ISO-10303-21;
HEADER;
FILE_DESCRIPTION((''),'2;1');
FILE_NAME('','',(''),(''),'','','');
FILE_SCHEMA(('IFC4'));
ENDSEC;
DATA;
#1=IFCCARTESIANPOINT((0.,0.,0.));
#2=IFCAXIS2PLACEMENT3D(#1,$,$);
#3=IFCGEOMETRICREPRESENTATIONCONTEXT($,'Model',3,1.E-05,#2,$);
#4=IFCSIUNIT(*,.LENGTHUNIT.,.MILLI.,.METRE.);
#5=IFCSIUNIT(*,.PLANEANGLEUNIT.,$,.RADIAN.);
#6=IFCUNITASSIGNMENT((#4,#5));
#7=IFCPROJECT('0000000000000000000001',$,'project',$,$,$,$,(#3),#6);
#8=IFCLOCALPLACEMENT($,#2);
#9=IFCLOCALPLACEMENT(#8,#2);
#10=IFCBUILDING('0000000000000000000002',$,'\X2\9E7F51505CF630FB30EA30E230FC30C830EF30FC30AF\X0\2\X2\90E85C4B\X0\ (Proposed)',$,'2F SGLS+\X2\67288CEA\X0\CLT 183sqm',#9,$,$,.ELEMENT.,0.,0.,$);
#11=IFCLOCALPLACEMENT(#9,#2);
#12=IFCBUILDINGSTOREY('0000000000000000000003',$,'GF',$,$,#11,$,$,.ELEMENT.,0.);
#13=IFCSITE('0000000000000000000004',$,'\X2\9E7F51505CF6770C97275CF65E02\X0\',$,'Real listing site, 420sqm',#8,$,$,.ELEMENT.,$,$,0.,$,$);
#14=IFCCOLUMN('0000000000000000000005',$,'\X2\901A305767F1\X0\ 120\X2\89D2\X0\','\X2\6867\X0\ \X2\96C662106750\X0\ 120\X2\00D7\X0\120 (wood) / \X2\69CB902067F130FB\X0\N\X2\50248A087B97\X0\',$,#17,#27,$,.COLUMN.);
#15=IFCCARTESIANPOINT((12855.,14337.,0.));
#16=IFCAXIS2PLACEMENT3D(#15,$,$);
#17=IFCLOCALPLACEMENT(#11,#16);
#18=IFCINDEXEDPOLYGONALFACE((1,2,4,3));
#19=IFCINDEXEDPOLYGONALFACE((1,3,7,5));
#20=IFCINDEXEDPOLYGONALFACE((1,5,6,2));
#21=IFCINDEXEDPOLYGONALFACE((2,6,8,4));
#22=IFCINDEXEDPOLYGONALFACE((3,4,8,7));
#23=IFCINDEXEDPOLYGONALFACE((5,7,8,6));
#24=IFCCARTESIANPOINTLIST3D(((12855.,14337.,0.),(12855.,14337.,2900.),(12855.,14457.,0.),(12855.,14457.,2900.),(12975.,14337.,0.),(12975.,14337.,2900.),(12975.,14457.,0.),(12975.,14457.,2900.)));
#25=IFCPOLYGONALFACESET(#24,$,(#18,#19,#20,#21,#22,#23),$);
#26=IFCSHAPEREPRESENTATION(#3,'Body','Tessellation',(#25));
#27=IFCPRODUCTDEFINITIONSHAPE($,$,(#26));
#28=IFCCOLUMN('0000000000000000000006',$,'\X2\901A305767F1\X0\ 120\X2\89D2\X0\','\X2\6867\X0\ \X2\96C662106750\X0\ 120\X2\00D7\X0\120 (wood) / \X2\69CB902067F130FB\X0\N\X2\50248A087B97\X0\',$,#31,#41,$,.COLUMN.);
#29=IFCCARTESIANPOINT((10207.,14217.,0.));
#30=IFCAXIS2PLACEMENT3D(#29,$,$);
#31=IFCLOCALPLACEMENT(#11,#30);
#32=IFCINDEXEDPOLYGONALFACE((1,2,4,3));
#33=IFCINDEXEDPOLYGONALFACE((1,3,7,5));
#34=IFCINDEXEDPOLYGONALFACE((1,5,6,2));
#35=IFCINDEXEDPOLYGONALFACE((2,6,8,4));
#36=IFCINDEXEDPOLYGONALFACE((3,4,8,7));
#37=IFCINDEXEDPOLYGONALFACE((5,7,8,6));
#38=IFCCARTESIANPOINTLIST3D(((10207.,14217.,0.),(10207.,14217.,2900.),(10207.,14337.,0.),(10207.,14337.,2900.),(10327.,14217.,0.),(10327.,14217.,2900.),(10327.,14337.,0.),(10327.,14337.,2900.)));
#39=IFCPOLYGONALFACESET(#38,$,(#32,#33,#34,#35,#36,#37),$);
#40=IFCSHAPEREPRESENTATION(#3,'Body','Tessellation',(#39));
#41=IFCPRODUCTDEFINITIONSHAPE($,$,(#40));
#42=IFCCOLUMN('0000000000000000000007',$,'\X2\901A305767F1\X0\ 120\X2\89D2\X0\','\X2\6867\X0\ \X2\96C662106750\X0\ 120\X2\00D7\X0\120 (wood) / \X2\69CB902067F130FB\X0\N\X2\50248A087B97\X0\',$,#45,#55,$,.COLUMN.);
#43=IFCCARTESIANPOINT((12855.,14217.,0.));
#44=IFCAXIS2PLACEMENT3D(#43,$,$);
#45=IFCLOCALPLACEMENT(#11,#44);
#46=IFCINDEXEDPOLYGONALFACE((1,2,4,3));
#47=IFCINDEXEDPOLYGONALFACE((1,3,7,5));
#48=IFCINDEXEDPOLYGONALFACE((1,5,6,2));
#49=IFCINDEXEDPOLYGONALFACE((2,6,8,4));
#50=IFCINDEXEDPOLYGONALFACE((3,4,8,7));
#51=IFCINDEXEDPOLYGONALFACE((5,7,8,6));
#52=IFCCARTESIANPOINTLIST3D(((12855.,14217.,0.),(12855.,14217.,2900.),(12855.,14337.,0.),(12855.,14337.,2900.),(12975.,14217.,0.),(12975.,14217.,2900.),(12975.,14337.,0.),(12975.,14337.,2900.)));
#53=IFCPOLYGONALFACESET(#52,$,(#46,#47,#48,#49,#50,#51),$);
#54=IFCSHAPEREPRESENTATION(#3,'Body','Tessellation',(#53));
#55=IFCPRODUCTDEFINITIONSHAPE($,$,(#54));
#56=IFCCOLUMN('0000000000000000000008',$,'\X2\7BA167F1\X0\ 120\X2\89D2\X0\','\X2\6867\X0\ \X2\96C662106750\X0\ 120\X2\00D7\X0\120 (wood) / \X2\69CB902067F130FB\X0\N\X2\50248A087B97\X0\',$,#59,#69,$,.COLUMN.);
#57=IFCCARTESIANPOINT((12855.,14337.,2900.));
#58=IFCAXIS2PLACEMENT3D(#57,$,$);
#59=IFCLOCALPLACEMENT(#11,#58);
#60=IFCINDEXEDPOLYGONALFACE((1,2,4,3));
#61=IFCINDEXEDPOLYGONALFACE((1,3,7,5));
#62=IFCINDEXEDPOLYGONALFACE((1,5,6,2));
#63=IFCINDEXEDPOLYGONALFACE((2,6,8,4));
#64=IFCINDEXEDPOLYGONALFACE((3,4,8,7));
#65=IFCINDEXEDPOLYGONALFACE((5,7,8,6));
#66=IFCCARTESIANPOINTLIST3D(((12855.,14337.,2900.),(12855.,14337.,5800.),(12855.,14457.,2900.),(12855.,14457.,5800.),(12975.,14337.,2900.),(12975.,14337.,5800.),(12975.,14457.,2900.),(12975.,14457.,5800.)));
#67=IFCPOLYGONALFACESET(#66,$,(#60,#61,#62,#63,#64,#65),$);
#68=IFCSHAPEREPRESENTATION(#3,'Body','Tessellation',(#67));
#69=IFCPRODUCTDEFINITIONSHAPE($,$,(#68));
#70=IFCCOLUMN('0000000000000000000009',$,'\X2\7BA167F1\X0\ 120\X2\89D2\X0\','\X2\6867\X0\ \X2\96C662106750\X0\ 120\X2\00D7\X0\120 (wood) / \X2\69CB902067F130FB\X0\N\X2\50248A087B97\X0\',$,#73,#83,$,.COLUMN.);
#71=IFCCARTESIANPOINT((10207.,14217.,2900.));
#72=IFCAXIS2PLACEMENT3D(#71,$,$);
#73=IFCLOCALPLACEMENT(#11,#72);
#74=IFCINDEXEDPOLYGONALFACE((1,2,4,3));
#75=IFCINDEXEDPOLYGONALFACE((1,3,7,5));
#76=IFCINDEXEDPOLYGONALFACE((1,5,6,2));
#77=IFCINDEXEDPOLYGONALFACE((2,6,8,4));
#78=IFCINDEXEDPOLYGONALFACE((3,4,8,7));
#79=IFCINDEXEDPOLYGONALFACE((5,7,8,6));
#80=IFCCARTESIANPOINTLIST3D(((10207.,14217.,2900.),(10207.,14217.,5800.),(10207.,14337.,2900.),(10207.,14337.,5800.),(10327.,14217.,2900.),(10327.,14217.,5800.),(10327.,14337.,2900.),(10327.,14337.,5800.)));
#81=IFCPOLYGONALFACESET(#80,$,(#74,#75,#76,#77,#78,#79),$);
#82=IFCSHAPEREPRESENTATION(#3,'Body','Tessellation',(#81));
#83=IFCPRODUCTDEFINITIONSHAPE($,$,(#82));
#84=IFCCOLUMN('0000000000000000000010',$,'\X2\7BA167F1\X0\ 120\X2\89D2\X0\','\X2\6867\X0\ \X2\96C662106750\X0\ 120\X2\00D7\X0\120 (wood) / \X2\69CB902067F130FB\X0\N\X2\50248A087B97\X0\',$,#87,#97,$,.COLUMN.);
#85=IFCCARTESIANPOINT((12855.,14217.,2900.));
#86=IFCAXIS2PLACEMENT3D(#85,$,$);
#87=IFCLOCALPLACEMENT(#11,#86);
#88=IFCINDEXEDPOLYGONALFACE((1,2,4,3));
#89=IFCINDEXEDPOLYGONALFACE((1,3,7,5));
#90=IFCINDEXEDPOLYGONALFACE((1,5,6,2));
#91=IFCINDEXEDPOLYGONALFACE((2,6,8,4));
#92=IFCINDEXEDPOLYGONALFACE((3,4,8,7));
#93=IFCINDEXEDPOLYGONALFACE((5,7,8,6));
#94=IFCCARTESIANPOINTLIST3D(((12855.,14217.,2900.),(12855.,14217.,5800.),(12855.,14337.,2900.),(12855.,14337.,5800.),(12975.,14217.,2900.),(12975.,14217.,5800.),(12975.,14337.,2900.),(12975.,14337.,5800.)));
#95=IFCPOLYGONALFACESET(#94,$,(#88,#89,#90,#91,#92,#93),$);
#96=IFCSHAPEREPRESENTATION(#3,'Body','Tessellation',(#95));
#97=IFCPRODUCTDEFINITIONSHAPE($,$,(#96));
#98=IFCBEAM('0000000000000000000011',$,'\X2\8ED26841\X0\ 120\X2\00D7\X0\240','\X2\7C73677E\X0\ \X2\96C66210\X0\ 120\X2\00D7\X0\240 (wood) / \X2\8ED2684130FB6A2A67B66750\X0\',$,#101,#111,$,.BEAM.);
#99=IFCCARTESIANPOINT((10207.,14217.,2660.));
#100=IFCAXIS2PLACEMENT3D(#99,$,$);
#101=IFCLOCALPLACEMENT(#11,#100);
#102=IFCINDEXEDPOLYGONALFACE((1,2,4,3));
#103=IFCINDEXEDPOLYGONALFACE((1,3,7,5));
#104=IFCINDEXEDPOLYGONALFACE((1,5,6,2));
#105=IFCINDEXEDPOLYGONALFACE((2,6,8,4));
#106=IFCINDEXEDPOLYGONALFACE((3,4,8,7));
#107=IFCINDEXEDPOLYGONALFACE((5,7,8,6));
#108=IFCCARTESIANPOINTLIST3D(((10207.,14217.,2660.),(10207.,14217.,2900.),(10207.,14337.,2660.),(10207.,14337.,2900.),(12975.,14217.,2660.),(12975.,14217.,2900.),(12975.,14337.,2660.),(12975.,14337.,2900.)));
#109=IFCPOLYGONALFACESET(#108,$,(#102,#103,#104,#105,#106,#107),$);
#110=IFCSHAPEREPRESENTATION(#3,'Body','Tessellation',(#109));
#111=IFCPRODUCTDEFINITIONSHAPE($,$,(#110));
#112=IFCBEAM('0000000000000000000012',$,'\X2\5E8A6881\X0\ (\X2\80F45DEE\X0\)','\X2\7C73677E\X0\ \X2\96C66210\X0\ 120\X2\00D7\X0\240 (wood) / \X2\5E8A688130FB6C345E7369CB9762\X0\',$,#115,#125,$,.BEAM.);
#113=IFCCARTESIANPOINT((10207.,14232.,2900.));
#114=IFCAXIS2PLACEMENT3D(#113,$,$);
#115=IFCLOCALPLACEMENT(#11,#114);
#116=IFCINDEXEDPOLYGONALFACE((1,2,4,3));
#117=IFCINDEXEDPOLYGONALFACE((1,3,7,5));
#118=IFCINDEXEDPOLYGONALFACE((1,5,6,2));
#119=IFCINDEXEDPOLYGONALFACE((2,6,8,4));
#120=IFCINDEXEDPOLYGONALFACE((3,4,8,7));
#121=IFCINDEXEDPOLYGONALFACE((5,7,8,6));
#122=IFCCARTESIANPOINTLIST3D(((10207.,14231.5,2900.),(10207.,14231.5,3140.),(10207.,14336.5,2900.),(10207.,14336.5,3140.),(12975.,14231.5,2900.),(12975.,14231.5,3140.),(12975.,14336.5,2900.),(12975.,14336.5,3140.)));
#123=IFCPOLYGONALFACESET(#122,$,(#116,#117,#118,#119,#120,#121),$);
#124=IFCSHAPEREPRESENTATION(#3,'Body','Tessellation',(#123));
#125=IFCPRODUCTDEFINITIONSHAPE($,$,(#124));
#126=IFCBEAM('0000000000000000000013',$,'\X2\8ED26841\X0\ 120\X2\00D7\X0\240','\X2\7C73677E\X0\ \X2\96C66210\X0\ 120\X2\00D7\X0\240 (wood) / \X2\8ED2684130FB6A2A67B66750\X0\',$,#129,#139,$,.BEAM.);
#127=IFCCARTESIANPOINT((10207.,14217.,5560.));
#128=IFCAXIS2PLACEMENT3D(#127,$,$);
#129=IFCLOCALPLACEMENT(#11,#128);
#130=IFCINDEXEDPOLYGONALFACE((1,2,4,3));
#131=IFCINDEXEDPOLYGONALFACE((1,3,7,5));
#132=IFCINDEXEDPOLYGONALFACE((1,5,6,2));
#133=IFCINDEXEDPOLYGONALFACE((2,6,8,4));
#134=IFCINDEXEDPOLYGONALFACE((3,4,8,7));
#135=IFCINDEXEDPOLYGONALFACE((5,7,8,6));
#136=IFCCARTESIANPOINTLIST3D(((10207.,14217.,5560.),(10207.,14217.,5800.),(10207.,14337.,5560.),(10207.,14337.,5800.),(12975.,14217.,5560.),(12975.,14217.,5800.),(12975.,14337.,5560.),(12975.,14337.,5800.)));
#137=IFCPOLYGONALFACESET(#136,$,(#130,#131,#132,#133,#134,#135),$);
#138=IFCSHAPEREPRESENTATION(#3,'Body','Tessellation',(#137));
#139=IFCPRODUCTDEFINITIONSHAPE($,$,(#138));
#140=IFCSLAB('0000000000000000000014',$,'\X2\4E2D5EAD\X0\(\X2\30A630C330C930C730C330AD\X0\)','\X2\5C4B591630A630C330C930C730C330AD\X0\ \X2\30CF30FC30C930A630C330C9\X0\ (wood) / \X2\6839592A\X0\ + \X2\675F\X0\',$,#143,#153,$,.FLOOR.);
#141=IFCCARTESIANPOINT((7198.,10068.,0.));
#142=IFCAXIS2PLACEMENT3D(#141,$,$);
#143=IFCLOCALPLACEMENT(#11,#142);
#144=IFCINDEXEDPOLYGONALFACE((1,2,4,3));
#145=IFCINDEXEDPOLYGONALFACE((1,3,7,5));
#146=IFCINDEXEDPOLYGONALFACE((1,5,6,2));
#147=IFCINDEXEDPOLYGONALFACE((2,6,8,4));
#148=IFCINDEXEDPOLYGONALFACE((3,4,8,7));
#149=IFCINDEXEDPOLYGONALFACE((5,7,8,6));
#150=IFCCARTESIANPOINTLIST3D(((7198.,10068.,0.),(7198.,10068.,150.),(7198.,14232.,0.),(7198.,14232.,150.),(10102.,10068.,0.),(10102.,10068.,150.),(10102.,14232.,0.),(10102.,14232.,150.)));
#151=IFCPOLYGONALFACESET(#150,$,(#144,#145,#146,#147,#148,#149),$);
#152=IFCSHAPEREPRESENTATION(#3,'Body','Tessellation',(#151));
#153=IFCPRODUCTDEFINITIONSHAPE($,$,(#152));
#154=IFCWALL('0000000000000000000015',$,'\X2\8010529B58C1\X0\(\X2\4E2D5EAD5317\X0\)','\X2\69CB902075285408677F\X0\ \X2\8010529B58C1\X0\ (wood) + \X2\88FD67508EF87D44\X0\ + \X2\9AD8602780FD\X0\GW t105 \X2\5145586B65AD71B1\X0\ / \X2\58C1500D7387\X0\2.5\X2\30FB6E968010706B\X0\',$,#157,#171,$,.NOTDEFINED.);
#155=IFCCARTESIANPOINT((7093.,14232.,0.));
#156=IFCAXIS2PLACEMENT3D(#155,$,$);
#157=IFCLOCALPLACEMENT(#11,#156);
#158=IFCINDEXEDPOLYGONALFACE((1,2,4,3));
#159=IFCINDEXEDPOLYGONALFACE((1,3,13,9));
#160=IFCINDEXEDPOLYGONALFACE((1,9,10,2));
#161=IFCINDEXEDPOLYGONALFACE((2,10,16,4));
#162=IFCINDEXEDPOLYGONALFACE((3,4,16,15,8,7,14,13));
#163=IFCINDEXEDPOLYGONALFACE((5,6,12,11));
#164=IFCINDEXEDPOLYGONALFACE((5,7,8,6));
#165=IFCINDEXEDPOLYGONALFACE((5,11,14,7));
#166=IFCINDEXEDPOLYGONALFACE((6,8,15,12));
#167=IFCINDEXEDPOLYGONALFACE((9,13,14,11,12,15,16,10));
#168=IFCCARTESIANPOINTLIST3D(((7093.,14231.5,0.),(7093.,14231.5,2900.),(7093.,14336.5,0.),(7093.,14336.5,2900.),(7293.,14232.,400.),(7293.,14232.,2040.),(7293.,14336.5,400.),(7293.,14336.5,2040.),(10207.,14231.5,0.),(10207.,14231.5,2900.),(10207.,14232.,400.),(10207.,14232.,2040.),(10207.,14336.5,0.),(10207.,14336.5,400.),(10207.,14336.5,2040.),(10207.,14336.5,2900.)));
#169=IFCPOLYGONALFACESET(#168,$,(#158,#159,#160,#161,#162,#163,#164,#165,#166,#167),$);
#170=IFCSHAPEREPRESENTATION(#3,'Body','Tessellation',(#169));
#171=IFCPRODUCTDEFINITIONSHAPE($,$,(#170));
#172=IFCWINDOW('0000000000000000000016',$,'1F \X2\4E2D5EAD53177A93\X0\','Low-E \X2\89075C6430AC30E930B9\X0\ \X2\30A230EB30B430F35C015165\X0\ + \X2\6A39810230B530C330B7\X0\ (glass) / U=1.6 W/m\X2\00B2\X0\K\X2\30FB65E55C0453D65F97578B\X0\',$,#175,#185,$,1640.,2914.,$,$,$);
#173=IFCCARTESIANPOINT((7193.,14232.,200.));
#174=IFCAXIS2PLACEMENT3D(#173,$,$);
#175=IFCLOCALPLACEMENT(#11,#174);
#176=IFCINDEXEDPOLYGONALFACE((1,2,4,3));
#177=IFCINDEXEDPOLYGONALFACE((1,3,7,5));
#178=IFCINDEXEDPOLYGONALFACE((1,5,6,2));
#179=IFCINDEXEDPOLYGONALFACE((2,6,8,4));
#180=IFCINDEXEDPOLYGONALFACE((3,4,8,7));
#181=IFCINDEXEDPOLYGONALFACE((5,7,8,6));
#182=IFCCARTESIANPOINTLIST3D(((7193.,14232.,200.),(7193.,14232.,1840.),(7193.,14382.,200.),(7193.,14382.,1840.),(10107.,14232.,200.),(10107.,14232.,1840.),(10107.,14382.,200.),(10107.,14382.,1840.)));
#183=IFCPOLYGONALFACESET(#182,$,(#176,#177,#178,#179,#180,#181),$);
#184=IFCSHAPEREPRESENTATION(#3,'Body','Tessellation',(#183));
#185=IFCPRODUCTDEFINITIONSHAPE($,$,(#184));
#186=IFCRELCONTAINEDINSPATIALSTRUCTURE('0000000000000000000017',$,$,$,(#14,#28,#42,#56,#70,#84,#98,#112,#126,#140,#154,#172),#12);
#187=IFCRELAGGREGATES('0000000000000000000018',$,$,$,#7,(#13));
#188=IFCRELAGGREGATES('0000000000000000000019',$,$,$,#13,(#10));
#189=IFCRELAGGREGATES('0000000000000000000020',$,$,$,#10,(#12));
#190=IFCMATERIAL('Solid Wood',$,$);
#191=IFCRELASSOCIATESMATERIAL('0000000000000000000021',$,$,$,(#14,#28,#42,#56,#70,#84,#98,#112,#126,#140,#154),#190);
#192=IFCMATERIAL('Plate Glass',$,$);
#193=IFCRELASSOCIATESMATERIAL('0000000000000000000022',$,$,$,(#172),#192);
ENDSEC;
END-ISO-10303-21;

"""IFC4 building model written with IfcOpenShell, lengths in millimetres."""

from ifc_helpers import new_model, si_unit, frame, frame_2d, origin, place, context, project, spatial, rectangle, extrude, material, element, fill, save


model = new_model("IFC4")

# Units and contexts
model_context = context("Model", 3, precision=1e-05, world=origin())
ifc_project = project(units=[si_unit("LENGTHUNIT", "METRE", prefix="MILLI"), si_unit("PLANEANGLEUNIT", "RADIAN")], contexts=[model_context])

# Site, building, storey
site_placement = place(None, origin())
site = spatial("IfcSite", under=ifc_project, at=site_placement, Name="鹿児島県霧島市", ObjectType="Real listing site, 420sqm", CompositionType="ELEMENT", RefElevation=0.0)
building_placement = place(site_placement, origin())
building = spatial("IfcBuilding", under=site, at=building_placement, Name="鹿児島・リモートワーク2部屋 (Proposed)", ObjectType="2F SGLS+木質CLT 183sqm", CompositionType="ELEMENT", ElevationOfRefHeight=0.0, ElevationOfTerrain=0.0)
storey_placement = place(building_placement, origin())
storey = spatial("IfcBuildingStorey", under=building, at=storey_placement, Name="GF", CompositionType="ELEMENT", Elevation=0.0)

# Columns
ifc_material_1 = material(Name="Solid Wood")
column_1_placement = place(storey_placement, frame((12855.0, 14337.0, 0.0)))
element("IfcColumn", 1, at=column_1_placement, inside=storey, material=ifc_material_1, Name="通し柱 120角", Description="桧 集成材 120×120 (wood) / 構造柱・N値計算", PredefinedType="COLUMN", context=model_context, shape_type="SweptSolid", body=[
    extrude(rectangle(XDim=120.0, YDim=120.0, at=frame_2d((60.0, 60.0))), frame((12855.0, 14337.0, 0.0)), (0.0, 0.0, 1.0), 2900.0),
])
column_2_placement = place(storey_placement, frame((10207.0, 14217.0, 0.0)))
element("IfcColumn", 2, at=column_2_placement, inside=storey, material=ifc_material_1, Name="通し柱 120角", Description="桧 集成材 120×120 (wood) / 構造柱・N値計算", PredefinedType="COLUMN", context=model_context, shape_type="SweptSolid", body=[
    extrude(rectangle(XDim=120.0, YDim=120.0, at=frame_2d((60.0, 60.0))), frame((10207.0, 14217.0, 0.0)), (0.0, 0.0, 1.0), 2900.0),
])
column_3_placement = place(storey_placement, frame((12855.0, 14217.0, 0.0)))
element("IfcColumn", 3, at=column_3_placement, inside=storey, material=ifc_material_1, Name="通し柱 120角", Description="桧 集成材 120×120 (wood) / 構造柱・N値計算", PredefinedType="COLUMN", context=model_context, shape_type="SweptSolid", body=[
    extrude(rectangle(XDim=120.0, YDim=120.0, at=frame_2d((60.0, 60.0))), frame((12855.0, 14217.0, 0.0)), (0.0, 0.0, 1.0), 2900.0),
])
column_4_placement = place(storey_placement, frame((12855.0, 14337.0, 2900.0)))
element("IfcColumn", 4, at=column_4_placement, inside=storey, material=ifc_material_1, Name="管柱 120角", Description="桧 集成材 120×120 (wood) / 構造柱・N値計算", PredefinedType="COLUMN", context=model_context, shape_type="SweptSolid", body=[
    extrude(rectangle(XDim=120.0, YDim=120.0, at=frame_2d((60.0, 60.0))), frame((12855.0, 14337.0, 2900.0)), (0.0, 0.0, 1.0), 2900.0),
])
column_5_placement = place(storey_placement, frame((10207.0, 14217.0, 2900.0)))
element("IfcColumn", 5, at=column_5_placement, inside=storey, material=ifc_material_1, Name="管柱 120角", Description="桧 集成材 120×120 (wood) / 構造柱・N値計算", PredefinedType="COLUMN", context=model_context, shape_type="SweptSolid", body=[
    extrude(rectangle(XDim=120.0, YDim=120.0, at=frame_2d((60.0, 60.0))), frame((10207.0, 14217.0, 2900.0)), (0.0, 0.0, 1.0), 2900.0),
])
column_6_placement = place(storey_placement, frame((12855.0, 14217.0, 2900.0)))
element("IfcColumn", 6, at=column_6_placement, inside=storey, material=ifc_material_1, Name="管柱 120角", Description="桧 集成材 120×120 (wood) / 構造柱・N値計算", PredefinedType="COLUMN", context=model_context, shape_type="SweptSolid", body=[
    extrude(rectangle(XDim=120.0, YDim=120.0, at=frame_2d((60.0, 60.0))), frame((12855.0, 14217.0, 2900.0)), (0.0, 0.0, 1.0), 2900.0),
])

# Beams
beam_1_placement = place(storey_placement, frame((10207.0, 14217.0, 2660.0)))
element("IfcBeam", 7, at=beam_1_placement, inside=storey, material=ifc_material_1, Name="軒桁 120×240", Description="米松 集成 120×240 (wood) / 軒桁・横架材", PredefinedType="BEAM", context=model_context, shape_type="SweptSolid", body=[
    extrude(rectangle(XDim=2768.0, YDim=120.0, at=frame_2d((1384.0, 60.0))), frame((10207.0, 14217.0, 2660.0)), (0.0, 0.0, 1.0), 240.0),
])
beam_2_placement = place(storey_placement, frame((10207.0, 14232.0, 2900.0)))
element("IfcBeam", 8, at=beam_2_placement, inside=storey, material=ifc_material_1, Name="床梁 (胴差)", Description="米松 集成 120×240 (wood) / 床梁・水平構面", PredefinedType="BEAM", context=model_context, shape_type="SweptSolid", body=[
    extrude(rectangle(XDim=2768.0, YDim=105.0, at=frame_2d((1384.0, 52.0))), frame((10207.0, 14232.0, 2900.0)), (0.0, 0.0, 1.0), 240.0),
])
beam_3_placement = place(storey_placement, frame((10207.0, 14217.0, 5560.0)))
element("IfcBeam", 9, at=beam_3_placement, inside=storey, material=ifc_material_1, Name="軒桁 120×240", Description="米松 集成 120×240 (wood) / 軒桁・横架材", PredefinedType="BEAM", context=model_context, shape_type="SweptSolid", body=[
    extrude(rectangle(XDim=2768.0, YDim=120.0, at=frame_2d((1384.0, 60.0))), frame((10207.0, 14217.0, 5560.0)), (0.0, 0.0, 1.0), 240.0),
])

# Slab
slab_placement = place(storey_placement, frame((7198.0, 10068.0, 0.0)))
element("IfcSlab", 10, at=slab_placement, inside=storey, material=ifc_material_1, Name="中庭(ウッドデッキ)", Description="屋外ウッドデッキ ハードウッド (wood) / 根太 + 束", PredefinedType="FLOOR", context=model_context, shape_type="SweptSolid", body=[
    extrude(rectangle(XDim=2904.0, YDim=4164.0, at=frame_2d((1452.0, 2082.0))), frame((7198.0, 10068.0, 0.0)), (0.0, 0.0, 1.0), 150.0),
])

# Wall, opening, window
wall_1_placement = place(storey_placement, frame((7093.0, 14232.0, 0.0)))
wall_1 = element("IfcWall", 11, at=wall_1_placement, inside=storey, material=ifc_material_1, Name="耐力壁(中庭北)", Description="構造用合板 耐力壁 (wood) + 製材軸組 + 高性能GW t105 充填断熱 / 壁倍率2.5・準耐火", PredefinedType="NOTDEFINED", context=model_context, shape_type="SweptSolid", body=[
    extrude(rectangle(XDim=3114.0, YDim=105.0, at=frame_2d((1557.0, 52.0))), frame((7093.0, 14232.0, 0.0)), (0.0, 0.0, 1.0), 2900.0),
])
opening_1_placement = place(storey_placement, frame((7193.0, 14232.0, 200.0)))
opening_1 = element("IfcOpeningElement", 12, at=opening_1_placement, cuts=wall_1, PredefinedType="NOTDEFINED", context=model_context, shape_type="SweptSolid", body=[
    extrude(rectangle(XDim=2914.0, YDim=150.0, at=frame_2d((1457.0, 75.0))), frame((7193.0, 14232.0, 200.0)), (0.0, 0.0, 1.0), 1640.0),
])
ifc_material_2 = material(Name="Plate Glass")
window_1_placement = place(storey_placement, frame((7193.0, 14232.0, 200.0)))
window_1 = element("IfcWindow", 13, at=window_1_placement, inside=storey, material=ifc_material_2, Name="1F 中庭北窓", Description="Low-E 複層ガラス アルゴン封入 + 樹脂サッシ (glass) / U=1.6 W/m²K・日射取得型", OverallHeight=1640.0, OverallWidth=2914.0, context=model_context, shape_type="SweptSolid", body=[
    extrude(rectangle(XDim=2914.0, YDim=150.0, at=frame_2d((1457.0, 75.0))), frame((7193.0, 14232.0, 200.0)), (0.0, 0.0, 1.0), 1640.0),
])
fill(opening_1, window_1)

save(model, "model.ifc")
